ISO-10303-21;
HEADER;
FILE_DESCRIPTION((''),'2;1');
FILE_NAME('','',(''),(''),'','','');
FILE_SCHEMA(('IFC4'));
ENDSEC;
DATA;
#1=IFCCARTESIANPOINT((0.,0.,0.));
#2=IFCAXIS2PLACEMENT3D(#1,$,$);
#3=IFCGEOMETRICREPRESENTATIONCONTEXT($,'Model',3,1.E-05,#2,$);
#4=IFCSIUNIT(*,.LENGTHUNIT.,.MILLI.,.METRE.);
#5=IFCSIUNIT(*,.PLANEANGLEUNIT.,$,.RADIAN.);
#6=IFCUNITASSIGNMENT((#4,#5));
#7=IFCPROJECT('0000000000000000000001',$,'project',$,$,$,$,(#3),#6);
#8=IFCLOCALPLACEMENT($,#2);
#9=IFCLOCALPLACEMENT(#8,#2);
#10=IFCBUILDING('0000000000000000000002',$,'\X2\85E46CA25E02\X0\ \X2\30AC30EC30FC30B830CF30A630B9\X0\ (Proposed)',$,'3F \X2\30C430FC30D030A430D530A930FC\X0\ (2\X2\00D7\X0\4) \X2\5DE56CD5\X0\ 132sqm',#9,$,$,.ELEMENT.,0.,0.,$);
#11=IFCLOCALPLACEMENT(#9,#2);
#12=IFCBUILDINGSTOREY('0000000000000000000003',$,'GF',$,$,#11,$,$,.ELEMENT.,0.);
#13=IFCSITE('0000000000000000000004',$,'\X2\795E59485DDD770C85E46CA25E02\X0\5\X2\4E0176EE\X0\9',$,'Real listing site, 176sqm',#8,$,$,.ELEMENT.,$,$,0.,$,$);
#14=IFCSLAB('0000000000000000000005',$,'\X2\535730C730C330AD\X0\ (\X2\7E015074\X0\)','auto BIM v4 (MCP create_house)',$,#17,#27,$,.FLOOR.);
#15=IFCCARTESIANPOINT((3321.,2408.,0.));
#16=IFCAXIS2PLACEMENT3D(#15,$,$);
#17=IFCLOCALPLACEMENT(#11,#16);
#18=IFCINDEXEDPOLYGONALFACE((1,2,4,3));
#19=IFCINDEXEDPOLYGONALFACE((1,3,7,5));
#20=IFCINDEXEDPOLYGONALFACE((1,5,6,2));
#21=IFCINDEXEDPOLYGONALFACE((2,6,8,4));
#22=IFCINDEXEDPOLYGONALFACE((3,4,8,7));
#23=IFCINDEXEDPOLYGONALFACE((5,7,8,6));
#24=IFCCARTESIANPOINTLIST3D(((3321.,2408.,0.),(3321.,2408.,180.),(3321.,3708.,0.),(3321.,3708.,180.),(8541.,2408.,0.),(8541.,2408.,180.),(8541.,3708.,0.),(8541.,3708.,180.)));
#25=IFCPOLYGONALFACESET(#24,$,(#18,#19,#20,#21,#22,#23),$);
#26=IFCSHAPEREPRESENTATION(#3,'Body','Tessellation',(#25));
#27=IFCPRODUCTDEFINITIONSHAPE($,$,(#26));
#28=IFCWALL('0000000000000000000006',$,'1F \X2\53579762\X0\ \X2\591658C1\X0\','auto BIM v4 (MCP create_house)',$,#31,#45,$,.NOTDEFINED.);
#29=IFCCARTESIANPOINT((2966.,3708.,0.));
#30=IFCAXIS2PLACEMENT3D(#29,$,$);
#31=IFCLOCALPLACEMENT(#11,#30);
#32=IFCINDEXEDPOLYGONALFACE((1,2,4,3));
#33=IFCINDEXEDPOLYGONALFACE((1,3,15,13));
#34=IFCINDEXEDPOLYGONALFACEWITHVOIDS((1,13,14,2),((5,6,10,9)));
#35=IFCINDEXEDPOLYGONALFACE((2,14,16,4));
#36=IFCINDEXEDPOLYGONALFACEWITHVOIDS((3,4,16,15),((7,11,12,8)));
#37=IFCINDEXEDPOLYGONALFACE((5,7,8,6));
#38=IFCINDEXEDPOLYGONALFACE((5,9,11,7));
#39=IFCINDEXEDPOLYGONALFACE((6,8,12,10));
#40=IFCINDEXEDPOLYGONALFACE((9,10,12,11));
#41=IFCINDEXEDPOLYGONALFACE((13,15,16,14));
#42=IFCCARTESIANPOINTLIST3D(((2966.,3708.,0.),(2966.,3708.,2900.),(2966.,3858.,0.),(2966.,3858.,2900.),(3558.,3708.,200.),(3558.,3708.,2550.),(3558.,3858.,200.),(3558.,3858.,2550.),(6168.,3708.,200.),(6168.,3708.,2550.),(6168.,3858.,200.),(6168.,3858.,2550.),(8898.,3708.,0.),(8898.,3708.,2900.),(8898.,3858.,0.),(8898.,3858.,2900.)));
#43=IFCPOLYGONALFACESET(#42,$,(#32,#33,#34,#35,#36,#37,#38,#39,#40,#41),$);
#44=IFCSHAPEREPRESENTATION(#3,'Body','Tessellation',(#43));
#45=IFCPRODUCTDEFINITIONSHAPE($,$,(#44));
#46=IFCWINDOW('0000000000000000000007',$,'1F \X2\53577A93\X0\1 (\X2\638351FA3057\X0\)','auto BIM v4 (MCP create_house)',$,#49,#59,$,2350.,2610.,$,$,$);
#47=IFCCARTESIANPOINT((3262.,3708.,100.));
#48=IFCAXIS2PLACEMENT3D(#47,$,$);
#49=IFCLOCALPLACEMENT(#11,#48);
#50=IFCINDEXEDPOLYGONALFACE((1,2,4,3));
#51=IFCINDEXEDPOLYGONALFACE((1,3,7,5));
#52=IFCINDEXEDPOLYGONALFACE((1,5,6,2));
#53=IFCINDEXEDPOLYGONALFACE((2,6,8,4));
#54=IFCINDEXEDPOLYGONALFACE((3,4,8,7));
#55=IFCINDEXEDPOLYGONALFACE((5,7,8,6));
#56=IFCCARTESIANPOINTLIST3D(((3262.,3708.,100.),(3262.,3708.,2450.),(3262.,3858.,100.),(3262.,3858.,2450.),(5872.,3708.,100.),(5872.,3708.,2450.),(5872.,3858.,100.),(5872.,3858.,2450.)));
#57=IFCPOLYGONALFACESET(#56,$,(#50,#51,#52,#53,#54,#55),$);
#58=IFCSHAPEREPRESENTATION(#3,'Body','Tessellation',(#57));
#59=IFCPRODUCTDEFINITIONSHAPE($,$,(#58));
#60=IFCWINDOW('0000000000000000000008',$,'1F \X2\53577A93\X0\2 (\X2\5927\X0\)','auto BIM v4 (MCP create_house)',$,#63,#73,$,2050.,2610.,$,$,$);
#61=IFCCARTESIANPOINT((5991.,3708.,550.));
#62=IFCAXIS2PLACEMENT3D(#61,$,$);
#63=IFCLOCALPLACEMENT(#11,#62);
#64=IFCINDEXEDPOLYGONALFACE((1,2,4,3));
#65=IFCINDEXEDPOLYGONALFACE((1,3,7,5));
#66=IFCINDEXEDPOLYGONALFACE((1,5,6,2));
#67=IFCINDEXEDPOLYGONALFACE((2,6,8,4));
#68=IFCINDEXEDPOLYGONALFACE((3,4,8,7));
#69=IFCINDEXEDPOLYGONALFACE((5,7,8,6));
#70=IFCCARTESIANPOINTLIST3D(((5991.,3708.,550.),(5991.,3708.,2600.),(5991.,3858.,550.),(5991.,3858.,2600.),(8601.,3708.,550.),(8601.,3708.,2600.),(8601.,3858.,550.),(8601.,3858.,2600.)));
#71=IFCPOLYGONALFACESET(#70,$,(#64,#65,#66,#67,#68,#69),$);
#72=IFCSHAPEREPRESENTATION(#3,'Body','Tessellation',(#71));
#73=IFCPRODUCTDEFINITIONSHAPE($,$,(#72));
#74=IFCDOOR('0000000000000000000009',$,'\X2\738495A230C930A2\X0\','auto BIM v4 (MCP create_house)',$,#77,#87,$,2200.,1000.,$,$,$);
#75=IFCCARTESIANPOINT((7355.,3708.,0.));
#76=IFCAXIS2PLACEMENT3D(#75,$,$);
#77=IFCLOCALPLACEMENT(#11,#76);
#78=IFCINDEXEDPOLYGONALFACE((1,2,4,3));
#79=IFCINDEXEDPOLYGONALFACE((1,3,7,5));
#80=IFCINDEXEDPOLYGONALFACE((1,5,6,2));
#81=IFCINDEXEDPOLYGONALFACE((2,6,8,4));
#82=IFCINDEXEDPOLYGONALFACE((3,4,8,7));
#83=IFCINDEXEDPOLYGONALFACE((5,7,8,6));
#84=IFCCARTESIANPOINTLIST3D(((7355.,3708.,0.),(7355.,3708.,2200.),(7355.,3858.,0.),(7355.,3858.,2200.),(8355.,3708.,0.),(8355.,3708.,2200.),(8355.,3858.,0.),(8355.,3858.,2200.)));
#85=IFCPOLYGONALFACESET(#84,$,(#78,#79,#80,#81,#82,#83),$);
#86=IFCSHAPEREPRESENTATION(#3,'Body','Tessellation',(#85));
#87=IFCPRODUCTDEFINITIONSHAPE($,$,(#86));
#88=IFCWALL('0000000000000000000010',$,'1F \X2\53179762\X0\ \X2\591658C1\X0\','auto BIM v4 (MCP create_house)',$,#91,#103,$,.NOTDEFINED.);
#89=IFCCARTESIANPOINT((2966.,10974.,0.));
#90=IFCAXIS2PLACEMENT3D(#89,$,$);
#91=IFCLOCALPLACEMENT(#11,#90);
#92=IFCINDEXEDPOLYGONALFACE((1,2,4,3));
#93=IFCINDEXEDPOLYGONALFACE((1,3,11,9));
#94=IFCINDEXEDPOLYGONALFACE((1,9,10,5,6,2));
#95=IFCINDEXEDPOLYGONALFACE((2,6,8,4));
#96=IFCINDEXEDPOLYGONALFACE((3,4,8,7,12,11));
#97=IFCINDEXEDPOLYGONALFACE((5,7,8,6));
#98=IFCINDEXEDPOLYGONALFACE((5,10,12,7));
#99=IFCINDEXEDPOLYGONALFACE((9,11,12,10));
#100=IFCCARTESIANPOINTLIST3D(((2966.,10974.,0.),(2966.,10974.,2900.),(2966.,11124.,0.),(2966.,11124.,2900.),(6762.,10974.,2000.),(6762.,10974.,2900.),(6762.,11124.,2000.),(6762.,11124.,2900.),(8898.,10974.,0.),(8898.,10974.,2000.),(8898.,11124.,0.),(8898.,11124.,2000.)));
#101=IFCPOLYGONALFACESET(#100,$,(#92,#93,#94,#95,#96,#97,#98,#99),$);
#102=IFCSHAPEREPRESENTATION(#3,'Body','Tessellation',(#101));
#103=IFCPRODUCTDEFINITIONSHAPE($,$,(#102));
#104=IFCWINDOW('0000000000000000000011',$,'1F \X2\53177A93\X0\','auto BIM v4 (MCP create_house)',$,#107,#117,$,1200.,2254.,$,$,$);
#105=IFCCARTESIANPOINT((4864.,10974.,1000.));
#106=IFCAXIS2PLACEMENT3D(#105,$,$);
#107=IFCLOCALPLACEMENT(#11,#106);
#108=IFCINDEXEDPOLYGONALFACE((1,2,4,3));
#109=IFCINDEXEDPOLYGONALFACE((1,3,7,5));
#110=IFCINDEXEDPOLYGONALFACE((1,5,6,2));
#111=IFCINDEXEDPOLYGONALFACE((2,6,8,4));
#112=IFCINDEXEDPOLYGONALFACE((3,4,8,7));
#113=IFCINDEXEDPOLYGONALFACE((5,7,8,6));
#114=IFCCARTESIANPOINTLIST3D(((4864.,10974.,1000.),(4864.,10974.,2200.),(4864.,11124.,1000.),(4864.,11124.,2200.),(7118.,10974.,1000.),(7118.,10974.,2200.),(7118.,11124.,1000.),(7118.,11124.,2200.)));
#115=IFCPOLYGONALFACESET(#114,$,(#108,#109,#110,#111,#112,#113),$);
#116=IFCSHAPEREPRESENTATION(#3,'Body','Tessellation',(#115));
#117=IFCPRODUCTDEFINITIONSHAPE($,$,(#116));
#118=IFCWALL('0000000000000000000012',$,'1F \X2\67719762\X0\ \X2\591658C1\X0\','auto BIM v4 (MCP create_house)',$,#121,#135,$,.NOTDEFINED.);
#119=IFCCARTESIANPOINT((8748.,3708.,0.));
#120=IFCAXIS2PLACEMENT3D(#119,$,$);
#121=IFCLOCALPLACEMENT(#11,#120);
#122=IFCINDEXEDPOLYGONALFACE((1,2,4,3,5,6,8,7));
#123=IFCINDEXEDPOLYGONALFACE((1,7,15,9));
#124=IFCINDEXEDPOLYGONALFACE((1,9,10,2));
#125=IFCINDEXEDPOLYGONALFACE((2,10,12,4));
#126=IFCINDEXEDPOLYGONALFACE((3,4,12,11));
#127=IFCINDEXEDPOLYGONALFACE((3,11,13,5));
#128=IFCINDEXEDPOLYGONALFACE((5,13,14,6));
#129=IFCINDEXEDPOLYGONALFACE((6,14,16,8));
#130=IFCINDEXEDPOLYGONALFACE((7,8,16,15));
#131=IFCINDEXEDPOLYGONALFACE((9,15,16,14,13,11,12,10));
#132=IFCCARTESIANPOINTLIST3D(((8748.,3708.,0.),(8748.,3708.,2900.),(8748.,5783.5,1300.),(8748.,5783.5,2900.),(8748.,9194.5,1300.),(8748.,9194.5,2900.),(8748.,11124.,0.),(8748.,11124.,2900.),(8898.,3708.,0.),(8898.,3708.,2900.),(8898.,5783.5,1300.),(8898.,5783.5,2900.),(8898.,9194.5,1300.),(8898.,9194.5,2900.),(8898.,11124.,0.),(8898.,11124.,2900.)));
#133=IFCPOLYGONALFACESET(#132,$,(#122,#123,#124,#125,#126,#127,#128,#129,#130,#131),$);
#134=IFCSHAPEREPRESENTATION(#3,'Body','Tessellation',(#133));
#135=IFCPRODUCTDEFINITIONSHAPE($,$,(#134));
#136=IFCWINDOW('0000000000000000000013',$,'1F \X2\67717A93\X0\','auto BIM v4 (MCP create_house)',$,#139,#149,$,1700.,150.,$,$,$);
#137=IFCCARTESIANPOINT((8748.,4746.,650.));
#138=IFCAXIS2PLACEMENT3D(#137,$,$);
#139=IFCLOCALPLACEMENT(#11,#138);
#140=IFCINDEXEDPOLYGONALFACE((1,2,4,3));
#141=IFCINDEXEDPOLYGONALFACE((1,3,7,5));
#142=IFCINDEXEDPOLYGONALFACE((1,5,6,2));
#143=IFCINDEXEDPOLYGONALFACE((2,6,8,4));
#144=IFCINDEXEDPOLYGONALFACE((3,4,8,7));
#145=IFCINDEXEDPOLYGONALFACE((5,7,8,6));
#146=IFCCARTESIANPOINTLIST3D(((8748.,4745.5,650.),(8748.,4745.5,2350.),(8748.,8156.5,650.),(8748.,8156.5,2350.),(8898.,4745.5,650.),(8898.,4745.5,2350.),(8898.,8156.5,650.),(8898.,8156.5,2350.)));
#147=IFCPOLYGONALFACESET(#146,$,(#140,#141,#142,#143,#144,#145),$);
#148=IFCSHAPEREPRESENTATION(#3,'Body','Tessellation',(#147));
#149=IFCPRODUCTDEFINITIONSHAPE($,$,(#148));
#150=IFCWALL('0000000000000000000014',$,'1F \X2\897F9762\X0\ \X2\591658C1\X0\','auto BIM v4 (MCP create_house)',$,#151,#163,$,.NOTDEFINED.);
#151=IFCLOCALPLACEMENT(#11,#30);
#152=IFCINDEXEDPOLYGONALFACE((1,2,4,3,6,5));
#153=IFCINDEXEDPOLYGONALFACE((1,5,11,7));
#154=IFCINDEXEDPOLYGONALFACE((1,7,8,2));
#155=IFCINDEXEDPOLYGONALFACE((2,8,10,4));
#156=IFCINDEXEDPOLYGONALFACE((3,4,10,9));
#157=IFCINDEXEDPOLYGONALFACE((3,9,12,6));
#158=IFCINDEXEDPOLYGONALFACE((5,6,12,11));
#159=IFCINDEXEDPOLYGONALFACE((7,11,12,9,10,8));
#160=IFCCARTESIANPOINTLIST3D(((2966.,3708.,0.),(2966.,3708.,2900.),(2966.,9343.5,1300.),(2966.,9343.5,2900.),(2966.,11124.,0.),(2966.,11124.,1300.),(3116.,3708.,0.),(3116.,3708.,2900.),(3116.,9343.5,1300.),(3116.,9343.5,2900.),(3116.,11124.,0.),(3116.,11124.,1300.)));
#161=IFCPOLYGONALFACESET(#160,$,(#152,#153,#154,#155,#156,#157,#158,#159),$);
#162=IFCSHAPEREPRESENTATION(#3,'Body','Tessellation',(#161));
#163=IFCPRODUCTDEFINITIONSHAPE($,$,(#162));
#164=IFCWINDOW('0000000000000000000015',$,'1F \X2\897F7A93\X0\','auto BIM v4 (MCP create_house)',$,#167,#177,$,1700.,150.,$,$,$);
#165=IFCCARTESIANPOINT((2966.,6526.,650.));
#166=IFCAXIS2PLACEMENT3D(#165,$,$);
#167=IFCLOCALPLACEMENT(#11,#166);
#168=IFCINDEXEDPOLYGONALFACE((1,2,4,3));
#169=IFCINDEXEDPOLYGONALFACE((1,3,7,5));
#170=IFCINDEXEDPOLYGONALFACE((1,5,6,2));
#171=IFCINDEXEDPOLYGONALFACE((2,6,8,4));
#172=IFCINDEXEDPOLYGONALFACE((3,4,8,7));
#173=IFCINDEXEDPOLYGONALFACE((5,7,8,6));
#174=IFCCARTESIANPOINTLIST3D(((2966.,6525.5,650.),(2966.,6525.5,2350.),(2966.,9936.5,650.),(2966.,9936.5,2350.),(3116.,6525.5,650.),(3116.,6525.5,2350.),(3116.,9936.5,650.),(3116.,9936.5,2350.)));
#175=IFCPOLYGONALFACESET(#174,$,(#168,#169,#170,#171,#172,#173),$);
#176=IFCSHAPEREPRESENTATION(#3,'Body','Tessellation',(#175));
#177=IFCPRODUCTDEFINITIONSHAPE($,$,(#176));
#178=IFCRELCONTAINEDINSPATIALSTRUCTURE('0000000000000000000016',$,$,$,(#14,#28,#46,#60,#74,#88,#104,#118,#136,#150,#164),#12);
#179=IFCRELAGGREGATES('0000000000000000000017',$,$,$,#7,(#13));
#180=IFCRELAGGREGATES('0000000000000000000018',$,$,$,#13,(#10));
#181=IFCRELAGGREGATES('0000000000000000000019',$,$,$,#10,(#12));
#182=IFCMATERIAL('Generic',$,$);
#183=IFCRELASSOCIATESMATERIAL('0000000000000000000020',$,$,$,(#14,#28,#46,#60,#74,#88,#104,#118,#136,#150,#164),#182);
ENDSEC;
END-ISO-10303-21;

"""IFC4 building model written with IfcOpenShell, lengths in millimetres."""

from ifc_helpers import new_model, si_unit, frame, frame_2d, origin, place, context, project, spatial, rectangle, extrude, material, element, fill, save


model = new_model("IFC4")

# Units and contexts
model_context = context("Model", 3, precision=1e-05, world=origin())
ifc_project = project(units=[si_unit("LENGTHUNIT", "METRE", prefix="MILLI"), si_unit("PLANEANGLEUNIT", "RADIAN")], contexts=[model_context])

# Site, building, storey
site_placement = place(None, origin())
site = spatial("IfcSite", under=ifc_project, at=site_placement, Name="神奈川県藤沢市5丁目9", ObjectType="Real listing site, 176sqm", CompositionType="ELEMENT", RefElevation=0.0)
building_placement = place(site_placement, origin())
building = spatial("IfcBuilding", under=site, at=building_placement, Name="藤沢市 ガレージハウス (Proposed)", ObjectType="3F ツーバイフォー (2×4) 工法 132sqm", CompositionType="ELEMENT", ElevationOfRefHeight=0.0, ElevationOfTerrain=0.0)
storey_placement = place(building_placement, origin())
storey = spatial("IfcBuildingStorey", under=building, at=storey_placement, Name="GF", CompositionType="ELEMENT", Elevation=0.0)

# Slab
ifc_material = material(Name="Generic")
slab_1_placement = place(storey_placement, frame((3321.0, 2408.0, 0.0)))
element("IfcSlab", 1, at=slab_1_placement, inside=storey, material=ifc_material, Name="南デッキ (縁側)", Description="auto BIM v4 (MCP create_house)", PredefinedType="FLOOR", context=model_context, shape_type="SweptSolid", body=[
    extrude(rectangle(XDim=5220.0, YDim=1300.0, at=frame_2d((2610.0, 650.0))), frame((3321.0, 2408.0, 0.0)), (0.0, 0.0, 1.0), 180.0),
])

# Wall, openings, windows, door
wall_1_placement = place(storey_placement, frame((2966.0, 3708.0, 0.0)))
wall_1 = element("IfcWall", 2, at=wall_1_placement, inside=storey, material=ifc_material, Name="1F 南面 外壁", Description="auto BIM v4 (MCP create_house)", PredefinedType="NOTDEFINED", context=model_context, shape_type="SweptSolid", body=[
    extrude(rectangle(XDim=5932.0, YDim=150.0, at=frame_2d((2966.0, 75.0))), frame((2966.0, 3708.0, 0.0)), (0.0, 0.0, 1.0), 2900.0),
])
opening_1_placement = place(storey_placement, frame((3262.0, 3708.0, 100.0)))
opening_1 = element("IfcOpeningElement", 3, at=opening_1_placement, cuts=wall_1, PredefinedType="NOTDEFINED", context=model_context, shape_type="SweptSolid", body=[
    extrude(rectangle(XDim=2610.0, YDim=150.0, at=frame_2d((1305.0, 75.0))), frame((3262.0, 3708.0, 100.0)), (0.0, 0.0, 1.0), 2350.0),
])
opening_2_placement = place(storey_placement, frame((5991.0, 3708.0, 550.0)))
opening_2 = element("IfcOpeningElement", 4, at=opening_2_placement, cuts=wall_1, PredefinedType="NOTDEFINED", context=model_context, shape_type="SweptSolid", body=[
    extrude(rectangle(XDim=2610.0, YDim=150.0, at=frame_2d((1305.0, 75.0))), frame((5991.0, 3708.0, 550.0)), (0.0, 0.0, 1.0), 2050.0),
])
opening_3_placement = place(storey_placement, frame((7355.0, 3708.0, 0.0)))
opening_3 = element("IfcOpeningElement", 5, at=opening_3_placement, cuts=wall_1, PredefinedType="NOTDEFINED", context=model_context, shape_type="SweptSolid", body=[
    extrude(rectangle(XDim=1000.0, YDim=150.0, at=frame_2d((500.0, 75.0))), frame((7355.0, 3708.0, 0.0)), (0.0, 0.0, 1.0), 2200.0),
])
window_1_placement = place(storey_placement, frame((3262.0, 3708.0, 100.0)))
window_1 = element("IfcWindow", 6, at=window_1_placement, inside=storey, material=ifc_material, Name="1F 南窓1 (掃出し)", Description="auto BIM v4 (MCP create_house)", OverallHeight=2350.0, OverallWidth=2610.0, context=model_context, shape_type="SweptSolid", body=[
    extrude(rectangle(XDim=2610.0, YDim=150.0, at=frame_2d((1305.0, 75.0))), frame((3262.0, 3708.0, 100.0)), (0.0, 0.0, 1.0), 2350.0),
])
fill(opening_1, window_1)
window_2_placement = place(storey_placement, frame((5991.0, 3708.0, 550.0)))
window_2 = element("IfcWindow", 7, at=window_2_placement, inside=storey, material=ifc_material, Name="1F 南窓2 (大)", Description="auto BIM v4 (MCP create_house)", OverallHeight=2050.0, OverallWidth=2610.0, context=model_context, shape_type="SweptSolid", body=[
    extrude(rectangle(XDim=2610.0, YDim=150.0, at=frame_2d((1305.0, 75.0))), frame((5991.0, 3708.0, 550.0)), (0.0, 0.0, 1.0), 2050.0),
])
fill(opening_2, window_2)
door_placement = place(storey_placement, frame((7355.0, 3708.0, 0.0)))
door = element("IfcDoor", 8, at=door_placement, inside=storey, material=ifc_material, Name="玄関ドア", Description="auto BIM v4 (MCP create_house)", OverallHeight=2200.0, OverallWidth=1000.0, context=model_context, shape_type="SweptSolid", body=[
    extrude(rectangle(XDim=1000.0, YDim=150.0, at=frame_2d((500.0, 75.0))), frame((7355.0, 3708.0, 0.0)), (0.0, 0.0, 1.0), 2200.0),
])
fill(opening_3, door)

# Walls, openings, windows
wall_2_placement = place(storey_placement, frame((2966.0, 10974.0, 0.0)))
wall_2 = element("IfcWall", 9, at=wall_2_placement, inside=storey, material=ifc_material, Name="1F 北面 外壁", Description="auto BIM v4 (MCP create_house)", PredefinedType="NOTDEFINED", context=model_context, shape_type="SweptSolid", body=[
    extrude(rectangle(XDim=5932.0, YDim=150.0, at=frame_2d((2966.0, 75.0))), frame((2966.0, 10974.0, 0.0)), (0.0, 0.0, 1.0), 2900.0),
])
opening_4_placement = place(storey_placement, frame((4864.0, 10974.0, 1000.0)))
opening_4 = element("IfcOpeningElement", 10, at=opening_4_placement, cuts=wall_2, PredefinedType="NOTDEFINED", context=model_context, shape_type="SweptSolid", body=[
    extrude(rectangle(XDim=2254.0, YDim=150.0, at=frame_2d((1127.0, 75.0))), frame((4864.0, 10974.0, 1000.0)), (0.0, 0.0, 1.0), 1200.0),
])
window_3_placement = place(storey_placement, frame((4864.0, 10974.0, 1000.0)))
window_3 = element("IfcWindow", 11, at=window_3_placement, inside=storey, material=ifc_material, Name="1F 北窓", Description="auto BIM v4 (MCP create_house)", OverallHeight=1200.0, OverallWidth=2254.0, context=model_context, shape_type="SweptSolid", body=[
    extrude(rectangle(XDim=2254.0, YDim=150.0, at=frame_2d((1127.0, 75.0))), frame((4864.0, 10974.0, 1000.0)), (0.0, 0.0, 1.0), 1200.0),
])
fill(opening_4, window_3)
wall_3_placement = place(storey_placement, frame((8748.0, 3708.0, 0.0)))
wall_3 = element("IfcWall", 12, at=wall_3_placement, inside=storey, material=ifc_material, Name="1F 東面 外壁", Description="auto BIM v4 (MCP create_house)", PredefinedType="NOTDEFINED", context=model_context, shape_type="SweptSolid", body=[
    extrude(rectangle(XDim=150.0, YDim=7416.0, at=frame_2d((75.0, 3708.0))), frame((8748.0, 3708.0, 0.0)), (0.0, 0.0, 1.0), 2900.0),
])
opening_5_placement = place(storey_placement, frame((8748.0, 4746.0, 650.0)))
opening_5 = element("IfcOpeningElement", 13, at=opening_5_placement, cuts=wall_3, PredefinedType="NOTDEFINED", context=model_context, shape_type="SweptSolid", body=[
    extrude(rectangle(XDim=150.0, YDim=3411.0, at=frame_2d((75.0, 1705.0))), frame((8748.0, 4746.0, 650.0)), (0.0, 0.0, 1.0), 1700.0),
])
window_4_placement = place(storey_placement, frame((8748.0, 4746.0, 650.0)))
window_4 = element("IfcWindow", 14, at=window_4_placement, inside=storey, material=ifc_material, Name="1F 東窓", Description="auto BIM v4 (MCP create_house)", OverallHeight=1700.0, OverallWidth=150.0, context=model_context, shape_type="SweptSolid", body=[
    extrude(rectangle(XDim=150.0, YDim=3411.0, at=frame_2d((75.0, 1705.0))), frame((8748.0, 4746.0, 650.0)), (0.0, 0.0, 1.0), 1700.0),
])
fill(opening_5, window_4)
wall_4_placement = place(storey_placement, frame((2966.0, 3708.0, 0.0)))
wall_4 = element("IfcWall", 15, at=wall_4_placement, inside=storey, material=ifc_material, Name="1F 西面 外壁", Description="auto BIM v4 (MCP create_house)", PredefinedType="NOTDEFINED", context=model_context, shape_type="SweptSolid", body=[
    extrude(rectangle(XDim=150.0, YDim=7416.0, at=frame_2d((75.0, 3708.0))), frame((2966.0, 3708.0, 0.0)), (0.0, 0.0, 1.0), 2900.0),
])
opening_6_placement = place(storey_placement, frame((2966.0, 6526.0, 650.0)))
opening_6 = element("IfcOpeningElement", 16, at=opening_6_placement, cuts=wall_4, PredefinedType="NOTDEFINED", context=model_context, shape_type="SweptSolid", body=[
    extrude(rectangle(XDim=150.0, YDim=3411.0, at=frame_2d((75.0, 1705.0))), frame((2966.0, 6526.0, 650.0)), (0.0, 0.0, 1.0), 1700.0),
])
window_5_placement = place(storey_placement, frame((2966.0, 6526.0, 650.0)))
window_5 = element("IfcWindow", 17, at=window_5_placement, inside=storey, material=ifc_material, Name="1F 西窓", Description="auto BIM v4 (MCP create_house)", OverallHeight=1700.0, OverallWidth=150.0, context=model_context, shape_type="SweptSolid", body=[
    extrude(rectangle(XDim=150.0, YDim=3411.0, at=frame_2d((75.0, 1705.0))), frame((2966.0, 6526.0, 650.0)), (0.0, 0.0, 1.0), 1700.0),
])
fill(opening_6, window_5)

save(model, "model.ifc")
